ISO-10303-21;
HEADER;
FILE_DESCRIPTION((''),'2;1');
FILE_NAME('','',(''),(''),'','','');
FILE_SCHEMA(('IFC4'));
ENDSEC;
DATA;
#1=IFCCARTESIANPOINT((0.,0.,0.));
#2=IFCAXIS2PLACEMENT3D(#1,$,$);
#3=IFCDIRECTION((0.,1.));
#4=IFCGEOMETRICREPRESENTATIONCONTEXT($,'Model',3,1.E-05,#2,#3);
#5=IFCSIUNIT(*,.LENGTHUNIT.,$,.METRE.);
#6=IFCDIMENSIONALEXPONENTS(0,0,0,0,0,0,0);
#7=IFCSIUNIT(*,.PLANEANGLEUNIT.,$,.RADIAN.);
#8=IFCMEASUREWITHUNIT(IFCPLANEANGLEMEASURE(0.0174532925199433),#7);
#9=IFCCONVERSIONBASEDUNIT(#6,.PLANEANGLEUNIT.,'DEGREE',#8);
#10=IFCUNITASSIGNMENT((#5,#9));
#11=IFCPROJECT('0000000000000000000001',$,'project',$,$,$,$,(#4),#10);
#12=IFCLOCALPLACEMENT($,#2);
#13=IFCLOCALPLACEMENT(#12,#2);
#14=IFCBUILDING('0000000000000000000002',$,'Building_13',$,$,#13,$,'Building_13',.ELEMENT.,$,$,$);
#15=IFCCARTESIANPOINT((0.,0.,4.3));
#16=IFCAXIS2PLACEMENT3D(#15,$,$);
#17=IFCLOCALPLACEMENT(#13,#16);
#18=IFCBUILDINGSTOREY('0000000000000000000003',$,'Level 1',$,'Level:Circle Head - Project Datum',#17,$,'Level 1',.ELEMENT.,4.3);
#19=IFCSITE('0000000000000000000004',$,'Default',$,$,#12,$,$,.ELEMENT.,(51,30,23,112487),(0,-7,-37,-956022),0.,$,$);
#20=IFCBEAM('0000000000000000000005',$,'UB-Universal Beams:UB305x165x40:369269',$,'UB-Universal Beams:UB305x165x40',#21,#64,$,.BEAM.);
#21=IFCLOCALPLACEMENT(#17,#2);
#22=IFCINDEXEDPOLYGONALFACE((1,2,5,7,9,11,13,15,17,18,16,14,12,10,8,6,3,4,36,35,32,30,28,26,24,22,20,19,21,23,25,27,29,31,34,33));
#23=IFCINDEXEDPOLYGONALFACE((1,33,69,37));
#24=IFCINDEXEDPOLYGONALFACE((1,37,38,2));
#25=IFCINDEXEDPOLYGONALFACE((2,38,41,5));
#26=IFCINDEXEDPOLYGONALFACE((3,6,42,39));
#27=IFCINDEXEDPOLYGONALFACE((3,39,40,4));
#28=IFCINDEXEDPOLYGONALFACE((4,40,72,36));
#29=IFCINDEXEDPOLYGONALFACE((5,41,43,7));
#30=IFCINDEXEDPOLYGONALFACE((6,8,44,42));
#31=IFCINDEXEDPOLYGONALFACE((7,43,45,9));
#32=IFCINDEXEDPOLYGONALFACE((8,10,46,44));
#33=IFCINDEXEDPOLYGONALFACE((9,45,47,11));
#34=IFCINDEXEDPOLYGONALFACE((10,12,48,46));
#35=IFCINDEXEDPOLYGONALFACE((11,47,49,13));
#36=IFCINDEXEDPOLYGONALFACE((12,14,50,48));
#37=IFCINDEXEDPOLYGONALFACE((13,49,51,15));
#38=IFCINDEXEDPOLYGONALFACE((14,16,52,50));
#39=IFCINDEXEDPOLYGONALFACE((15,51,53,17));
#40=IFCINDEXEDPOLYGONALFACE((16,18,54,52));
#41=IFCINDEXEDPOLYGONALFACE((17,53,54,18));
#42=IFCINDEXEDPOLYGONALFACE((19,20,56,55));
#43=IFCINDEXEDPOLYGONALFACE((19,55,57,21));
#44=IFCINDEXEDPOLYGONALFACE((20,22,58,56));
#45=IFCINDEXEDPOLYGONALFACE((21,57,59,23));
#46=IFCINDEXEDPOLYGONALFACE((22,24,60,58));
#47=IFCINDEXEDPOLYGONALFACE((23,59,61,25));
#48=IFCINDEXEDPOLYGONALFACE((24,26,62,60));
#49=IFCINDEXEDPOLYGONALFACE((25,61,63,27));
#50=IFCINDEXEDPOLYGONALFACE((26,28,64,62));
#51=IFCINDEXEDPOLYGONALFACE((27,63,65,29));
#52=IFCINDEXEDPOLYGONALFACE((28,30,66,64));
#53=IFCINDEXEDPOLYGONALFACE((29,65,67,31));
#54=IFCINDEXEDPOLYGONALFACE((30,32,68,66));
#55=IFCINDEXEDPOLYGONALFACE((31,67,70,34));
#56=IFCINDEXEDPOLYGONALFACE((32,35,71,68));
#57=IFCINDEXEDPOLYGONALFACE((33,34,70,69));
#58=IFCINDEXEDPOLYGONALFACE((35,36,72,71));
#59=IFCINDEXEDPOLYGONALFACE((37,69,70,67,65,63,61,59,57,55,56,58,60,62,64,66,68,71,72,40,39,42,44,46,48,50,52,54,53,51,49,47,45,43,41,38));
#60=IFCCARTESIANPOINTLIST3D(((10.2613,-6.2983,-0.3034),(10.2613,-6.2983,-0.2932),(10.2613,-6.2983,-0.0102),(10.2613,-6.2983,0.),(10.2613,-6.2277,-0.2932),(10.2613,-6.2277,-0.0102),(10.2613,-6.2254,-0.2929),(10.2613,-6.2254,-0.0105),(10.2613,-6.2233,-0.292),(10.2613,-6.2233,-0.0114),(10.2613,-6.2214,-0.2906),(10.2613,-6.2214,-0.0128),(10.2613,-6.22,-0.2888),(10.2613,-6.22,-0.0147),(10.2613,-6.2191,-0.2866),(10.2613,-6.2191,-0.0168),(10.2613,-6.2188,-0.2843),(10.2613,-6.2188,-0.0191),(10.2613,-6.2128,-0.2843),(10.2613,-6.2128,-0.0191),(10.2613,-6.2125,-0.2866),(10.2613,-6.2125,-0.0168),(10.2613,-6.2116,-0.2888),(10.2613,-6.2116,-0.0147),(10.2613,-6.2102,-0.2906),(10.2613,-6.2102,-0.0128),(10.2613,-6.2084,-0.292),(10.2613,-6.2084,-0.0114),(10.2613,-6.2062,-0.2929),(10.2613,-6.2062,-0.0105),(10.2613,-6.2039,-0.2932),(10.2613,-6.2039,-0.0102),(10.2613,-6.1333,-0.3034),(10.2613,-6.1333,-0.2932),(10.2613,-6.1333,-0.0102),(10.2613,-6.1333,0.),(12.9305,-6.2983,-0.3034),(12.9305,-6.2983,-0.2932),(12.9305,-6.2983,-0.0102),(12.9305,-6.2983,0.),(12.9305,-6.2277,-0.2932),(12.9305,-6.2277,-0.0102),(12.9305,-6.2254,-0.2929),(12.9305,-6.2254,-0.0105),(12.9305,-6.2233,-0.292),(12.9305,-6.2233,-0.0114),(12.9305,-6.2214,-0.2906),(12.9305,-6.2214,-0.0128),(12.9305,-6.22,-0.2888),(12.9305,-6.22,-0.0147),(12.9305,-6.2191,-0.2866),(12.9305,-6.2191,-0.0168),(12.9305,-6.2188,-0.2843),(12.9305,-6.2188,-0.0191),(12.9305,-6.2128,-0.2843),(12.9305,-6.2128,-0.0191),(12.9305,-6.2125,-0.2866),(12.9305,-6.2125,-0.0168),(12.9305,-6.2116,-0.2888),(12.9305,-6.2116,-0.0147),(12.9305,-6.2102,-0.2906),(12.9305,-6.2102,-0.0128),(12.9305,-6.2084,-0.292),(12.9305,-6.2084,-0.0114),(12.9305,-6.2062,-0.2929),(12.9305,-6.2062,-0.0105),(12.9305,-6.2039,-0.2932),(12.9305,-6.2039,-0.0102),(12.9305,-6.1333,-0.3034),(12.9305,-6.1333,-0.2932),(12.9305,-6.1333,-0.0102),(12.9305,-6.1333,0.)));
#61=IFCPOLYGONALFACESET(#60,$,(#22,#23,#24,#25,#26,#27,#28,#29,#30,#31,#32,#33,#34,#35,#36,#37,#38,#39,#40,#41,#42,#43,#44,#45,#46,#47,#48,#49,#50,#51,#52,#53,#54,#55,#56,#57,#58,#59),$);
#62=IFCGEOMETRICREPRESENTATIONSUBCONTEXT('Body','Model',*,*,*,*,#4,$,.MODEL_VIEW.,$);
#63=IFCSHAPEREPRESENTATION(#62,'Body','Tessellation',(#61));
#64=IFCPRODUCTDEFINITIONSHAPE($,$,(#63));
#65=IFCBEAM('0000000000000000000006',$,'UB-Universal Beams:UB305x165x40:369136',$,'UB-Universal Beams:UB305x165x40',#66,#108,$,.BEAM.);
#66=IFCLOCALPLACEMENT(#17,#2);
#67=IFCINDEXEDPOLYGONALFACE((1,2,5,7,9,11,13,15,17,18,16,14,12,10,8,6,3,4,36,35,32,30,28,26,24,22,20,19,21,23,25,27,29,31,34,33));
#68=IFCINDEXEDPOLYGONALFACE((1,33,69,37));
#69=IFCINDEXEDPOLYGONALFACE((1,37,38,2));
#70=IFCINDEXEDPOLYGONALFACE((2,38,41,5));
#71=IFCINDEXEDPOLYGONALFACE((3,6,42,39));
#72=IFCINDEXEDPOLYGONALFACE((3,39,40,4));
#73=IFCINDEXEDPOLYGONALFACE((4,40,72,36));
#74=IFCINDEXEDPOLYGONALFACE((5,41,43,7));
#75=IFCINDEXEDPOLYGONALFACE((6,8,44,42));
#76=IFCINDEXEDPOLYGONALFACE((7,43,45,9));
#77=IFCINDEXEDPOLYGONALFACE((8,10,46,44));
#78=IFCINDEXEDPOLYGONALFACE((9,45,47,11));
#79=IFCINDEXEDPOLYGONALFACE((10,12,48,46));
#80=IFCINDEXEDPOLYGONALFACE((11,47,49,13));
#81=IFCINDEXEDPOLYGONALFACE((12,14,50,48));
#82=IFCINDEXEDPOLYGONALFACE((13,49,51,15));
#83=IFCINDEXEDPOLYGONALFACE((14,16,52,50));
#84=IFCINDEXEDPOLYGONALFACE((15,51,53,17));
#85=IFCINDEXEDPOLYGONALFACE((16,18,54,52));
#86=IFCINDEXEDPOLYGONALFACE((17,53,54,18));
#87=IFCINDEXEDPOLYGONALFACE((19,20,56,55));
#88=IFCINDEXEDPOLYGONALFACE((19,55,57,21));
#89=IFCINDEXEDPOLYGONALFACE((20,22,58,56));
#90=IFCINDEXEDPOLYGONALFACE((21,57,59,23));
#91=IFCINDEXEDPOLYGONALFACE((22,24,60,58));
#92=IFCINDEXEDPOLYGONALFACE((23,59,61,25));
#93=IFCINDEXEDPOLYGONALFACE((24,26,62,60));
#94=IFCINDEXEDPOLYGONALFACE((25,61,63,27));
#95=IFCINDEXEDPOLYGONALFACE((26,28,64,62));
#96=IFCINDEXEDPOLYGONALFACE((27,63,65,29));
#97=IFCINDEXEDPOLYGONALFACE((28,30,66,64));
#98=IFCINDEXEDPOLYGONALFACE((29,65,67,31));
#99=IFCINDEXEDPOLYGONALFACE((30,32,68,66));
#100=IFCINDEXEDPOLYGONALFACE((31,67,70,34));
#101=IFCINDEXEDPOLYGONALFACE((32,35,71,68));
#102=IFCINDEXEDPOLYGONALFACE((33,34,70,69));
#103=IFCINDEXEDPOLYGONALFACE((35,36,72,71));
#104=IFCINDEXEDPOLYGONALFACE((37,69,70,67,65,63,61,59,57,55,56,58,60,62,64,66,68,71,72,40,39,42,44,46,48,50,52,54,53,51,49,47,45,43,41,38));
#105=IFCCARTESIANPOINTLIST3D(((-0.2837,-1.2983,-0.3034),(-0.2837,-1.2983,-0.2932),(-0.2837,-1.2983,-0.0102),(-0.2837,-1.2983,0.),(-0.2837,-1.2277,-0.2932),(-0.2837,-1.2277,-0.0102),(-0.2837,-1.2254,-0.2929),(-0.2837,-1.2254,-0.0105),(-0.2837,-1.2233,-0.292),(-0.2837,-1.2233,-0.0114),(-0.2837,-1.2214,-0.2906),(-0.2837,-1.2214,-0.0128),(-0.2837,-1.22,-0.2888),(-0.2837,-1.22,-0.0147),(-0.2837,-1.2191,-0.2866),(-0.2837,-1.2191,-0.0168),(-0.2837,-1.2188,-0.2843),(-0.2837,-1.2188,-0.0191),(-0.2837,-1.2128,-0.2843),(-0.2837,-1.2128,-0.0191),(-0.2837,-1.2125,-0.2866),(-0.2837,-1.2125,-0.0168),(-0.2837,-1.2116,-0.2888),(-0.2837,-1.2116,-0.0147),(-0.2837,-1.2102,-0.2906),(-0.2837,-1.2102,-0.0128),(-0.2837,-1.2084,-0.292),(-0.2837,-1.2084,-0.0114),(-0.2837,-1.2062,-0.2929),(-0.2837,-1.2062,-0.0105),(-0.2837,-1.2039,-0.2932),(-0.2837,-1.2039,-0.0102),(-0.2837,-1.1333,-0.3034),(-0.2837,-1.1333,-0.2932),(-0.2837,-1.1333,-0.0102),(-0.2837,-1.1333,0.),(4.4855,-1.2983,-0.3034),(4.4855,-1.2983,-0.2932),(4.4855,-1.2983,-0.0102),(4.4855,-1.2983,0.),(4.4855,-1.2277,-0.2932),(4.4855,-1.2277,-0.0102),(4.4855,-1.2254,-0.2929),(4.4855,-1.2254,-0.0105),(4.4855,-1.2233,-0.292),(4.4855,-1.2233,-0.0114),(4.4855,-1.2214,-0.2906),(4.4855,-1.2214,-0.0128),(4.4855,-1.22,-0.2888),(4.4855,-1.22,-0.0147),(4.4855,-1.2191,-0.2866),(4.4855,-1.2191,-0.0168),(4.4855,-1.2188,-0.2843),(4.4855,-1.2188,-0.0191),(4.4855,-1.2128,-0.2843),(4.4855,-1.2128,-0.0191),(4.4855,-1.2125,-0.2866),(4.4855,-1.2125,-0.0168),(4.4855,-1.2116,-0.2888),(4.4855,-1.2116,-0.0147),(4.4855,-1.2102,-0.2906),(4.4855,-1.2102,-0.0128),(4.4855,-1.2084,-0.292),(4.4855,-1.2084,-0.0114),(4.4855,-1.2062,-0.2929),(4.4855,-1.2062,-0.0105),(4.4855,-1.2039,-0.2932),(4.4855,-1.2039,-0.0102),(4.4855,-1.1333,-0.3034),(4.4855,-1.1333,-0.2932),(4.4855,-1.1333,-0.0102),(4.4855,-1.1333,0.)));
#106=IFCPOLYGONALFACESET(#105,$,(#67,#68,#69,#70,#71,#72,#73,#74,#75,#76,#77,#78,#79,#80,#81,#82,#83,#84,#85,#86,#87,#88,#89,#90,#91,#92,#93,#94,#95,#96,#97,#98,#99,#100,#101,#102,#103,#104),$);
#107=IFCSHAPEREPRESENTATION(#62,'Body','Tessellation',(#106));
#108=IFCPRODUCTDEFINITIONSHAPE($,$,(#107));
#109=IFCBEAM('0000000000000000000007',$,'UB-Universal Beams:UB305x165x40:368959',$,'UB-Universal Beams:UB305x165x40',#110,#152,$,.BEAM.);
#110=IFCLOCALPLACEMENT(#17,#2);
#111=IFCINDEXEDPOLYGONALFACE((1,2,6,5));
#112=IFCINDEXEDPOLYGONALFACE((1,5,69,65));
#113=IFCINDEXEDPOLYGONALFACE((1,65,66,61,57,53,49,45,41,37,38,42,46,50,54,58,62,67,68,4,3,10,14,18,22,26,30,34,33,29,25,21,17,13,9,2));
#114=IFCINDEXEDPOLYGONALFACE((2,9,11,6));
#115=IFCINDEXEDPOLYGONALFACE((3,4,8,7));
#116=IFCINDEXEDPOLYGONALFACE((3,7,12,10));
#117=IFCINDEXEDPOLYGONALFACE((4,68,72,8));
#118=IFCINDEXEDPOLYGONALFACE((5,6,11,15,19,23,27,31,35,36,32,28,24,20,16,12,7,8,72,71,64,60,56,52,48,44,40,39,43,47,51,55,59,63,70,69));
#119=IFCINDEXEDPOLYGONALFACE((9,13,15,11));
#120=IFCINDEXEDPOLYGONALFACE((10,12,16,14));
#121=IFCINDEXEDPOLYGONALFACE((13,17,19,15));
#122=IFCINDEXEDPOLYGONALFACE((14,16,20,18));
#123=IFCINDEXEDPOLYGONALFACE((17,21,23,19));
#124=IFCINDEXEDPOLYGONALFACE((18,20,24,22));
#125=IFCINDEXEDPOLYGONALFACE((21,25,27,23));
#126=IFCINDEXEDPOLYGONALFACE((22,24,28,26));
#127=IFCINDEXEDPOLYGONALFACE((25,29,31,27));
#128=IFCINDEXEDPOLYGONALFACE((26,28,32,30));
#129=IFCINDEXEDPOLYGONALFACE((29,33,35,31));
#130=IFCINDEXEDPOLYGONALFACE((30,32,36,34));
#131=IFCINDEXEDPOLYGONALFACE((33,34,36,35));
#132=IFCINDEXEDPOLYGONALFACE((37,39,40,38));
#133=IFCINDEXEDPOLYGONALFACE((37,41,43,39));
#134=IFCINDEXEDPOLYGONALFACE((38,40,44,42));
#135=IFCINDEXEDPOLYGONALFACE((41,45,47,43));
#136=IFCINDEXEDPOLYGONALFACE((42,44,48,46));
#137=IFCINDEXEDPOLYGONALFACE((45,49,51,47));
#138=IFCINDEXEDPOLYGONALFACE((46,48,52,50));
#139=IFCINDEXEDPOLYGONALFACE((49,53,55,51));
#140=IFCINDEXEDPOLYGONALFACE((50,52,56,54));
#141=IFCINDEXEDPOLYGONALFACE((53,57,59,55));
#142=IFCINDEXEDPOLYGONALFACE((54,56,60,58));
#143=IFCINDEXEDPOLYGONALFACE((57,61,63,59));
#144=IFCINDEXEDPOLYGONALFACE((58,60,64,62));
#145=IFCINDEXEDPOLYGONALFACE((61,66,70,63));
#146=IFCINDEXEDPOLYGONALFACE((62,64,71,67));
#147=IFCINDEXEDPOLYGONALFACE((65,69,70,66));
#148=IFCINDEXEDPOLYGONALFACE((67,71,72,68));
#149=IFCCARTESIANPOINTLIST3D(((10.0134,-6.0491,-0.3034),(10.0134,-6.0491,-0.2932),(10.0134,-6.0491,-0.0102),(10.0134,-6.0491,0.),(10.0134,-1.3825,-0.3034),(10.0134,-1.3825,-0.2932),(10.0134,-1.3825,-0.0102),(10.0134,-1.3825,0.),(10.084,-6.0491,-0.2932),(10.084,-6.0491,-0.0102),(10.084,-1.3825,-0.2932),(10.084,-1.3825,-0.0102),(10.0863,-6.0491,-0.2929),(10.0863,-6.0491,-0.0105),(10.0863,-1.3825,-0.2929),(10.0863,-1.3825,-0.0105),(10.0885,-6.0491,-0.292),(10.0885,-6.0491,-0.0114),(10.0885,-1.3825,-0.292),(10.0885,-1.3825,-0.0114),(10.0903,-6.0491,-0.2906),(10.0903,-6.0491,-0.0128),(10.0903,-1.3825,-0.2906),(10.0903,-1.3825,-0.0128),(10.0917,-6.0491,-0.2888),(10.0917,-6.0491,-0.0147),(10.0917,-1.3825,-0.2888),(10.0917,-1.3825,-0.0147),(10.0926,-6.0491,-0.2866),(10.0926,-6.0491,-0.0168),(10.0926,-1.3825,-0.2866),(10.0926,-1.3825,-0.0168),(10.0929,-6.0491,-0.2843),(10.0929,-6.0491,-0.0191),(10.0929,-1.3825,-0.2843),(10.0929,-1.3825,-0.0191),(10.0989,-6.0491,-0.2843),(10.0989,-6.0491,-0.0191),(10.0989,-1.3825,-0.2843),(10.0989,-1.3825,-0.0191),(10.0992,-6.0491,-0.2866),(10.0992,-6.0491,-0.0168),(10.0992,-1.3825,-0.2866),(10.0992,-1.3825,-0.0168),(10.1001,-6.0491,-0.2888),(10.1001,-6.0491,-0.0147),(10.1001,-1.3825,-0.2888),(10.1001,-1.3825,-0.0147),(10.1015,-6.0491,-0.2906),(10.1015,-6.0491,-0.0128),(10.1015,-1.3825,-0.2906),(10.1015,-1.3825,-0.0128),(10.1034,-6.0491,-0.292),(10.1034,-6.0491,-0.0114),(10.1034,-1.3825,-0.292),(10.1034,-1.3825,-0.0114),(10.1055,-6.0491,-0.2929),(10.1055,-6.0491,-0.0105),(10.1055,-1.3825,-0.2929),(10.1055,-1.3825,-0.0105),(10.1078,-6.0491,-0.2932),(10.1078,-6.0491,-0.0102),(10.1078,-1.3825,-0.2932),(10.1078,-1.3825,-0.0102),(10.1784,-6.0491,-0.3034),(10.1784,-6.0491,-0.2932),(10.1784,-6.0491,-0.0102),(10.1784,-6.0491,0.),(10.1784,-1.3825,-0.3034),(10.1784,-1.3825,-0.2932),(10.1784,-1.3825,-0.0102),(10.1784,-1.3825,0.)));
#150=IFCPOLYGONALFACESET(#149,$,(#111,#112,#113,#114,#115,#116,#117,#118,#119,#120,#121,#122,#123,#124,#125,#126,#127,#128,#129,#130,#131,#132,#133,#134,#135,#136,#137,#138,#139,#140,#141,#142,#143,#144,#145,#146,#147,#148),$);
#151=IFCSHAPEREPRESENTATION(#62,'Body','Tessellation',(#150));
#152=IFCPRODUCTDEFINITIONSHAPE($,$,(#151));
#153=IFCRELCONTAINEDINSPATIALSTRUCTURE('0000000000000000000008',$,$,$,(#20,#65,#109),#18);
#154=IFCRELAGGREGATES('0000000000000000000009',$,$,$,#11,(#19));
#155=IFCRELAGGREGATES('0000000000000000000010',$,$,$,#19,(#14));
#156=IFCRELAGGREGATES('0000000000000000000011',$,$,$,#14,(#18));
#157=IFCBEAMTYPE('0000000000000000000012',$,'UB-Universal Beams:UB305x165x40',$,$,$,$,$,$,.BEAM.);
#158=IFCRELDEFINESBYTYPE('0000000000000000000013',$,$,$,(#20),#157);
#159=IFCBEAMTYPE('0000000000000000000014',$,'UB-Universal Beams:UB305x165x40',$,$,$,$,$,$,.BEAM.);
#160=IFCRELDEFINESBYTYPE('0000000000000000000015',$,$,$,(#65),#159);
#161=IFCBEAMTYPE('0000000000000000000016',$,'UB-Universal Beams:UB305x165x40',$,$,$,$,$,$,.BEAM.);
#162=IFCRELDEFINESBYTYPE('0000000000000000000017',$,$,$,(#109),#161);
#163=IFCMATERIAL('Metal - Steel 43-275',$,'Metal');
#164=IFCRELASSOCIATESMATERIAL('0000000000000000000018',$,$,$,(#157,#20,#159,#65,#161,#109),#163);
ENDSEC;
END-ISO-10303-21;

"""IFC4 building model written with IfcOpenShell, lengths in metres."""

from ifc_helpers import new_model, entity, si_unit, converted_unit, direction, frame, origin, place, context, subcontext, project, spatial, line, arc, indexed_curve, outline, extrude, source, transform, mapped, material, type_object, type_shapes, element, save


model = new_model("IFC4")

# Units and contexts
model_context = context("Model", 3, precision=1e-05, world=origin(), true_north=direction((0.0, 1.0)))
body_context = subcontext(model_context, "Body", "Model", "MODEL_VIEW")
ifc_project = project(units=[si_unit("LENGTHUNIT", "METRE"), converted_unit("PLANEANGLEUNIT", "DEGREE", entity("IfcPlaneAngleMeasure", 0.0174532925199433), si_unit("PLANEANGLEUNIT", "RADIAN"), dimensions=[0, 0, 0, 0, 0, 0, 0])], contexts=[model_context])

# Site, building, storey
site_placement = place(None, origin())
site = spatial("IfcSite", under=ifc_project, at=site_placement, Name="Default", CompositionType="ELEMENT", RefLatitude=(51, 30, 23, 112487), RefLongitude=(0, -7, -37, -956022), RefElevation=0.0)
building_placement = place(site_placement, origin())
building = spatial("IfcBuilding", under=site, at=building_placement, Name="Building_13", LongName="Building_13", CompositionType="ELEMENT")
storey_placement = place(building_placement, frame((0.0, 0.0, 4.3)))
storey = spatial("IfcBuildingStorey", under=building, at=storey_placement, Name="Level 1", ObjectType="Level:Circle Head - Project Datum", LongName="Level 1", CompositionType="ELEMENT", Elevation=4.3)

# Beams
ifc_material_1 = material(Name="Metal - Steel 43-275", Category="Metal")
beam_type_1 = type_object("IfcBeamType", Name="UB-Universal Beams:UB305x165x40", PredefinedType="BEAM", material=ifc_material_1)
shared_shape_1 = source(origin(), body_context, "Body", "SweptSolid", [
    extrude(outline(indexed_curve([(-0.0825, -0.1415), (-0.0825, -0.1517), (0.0825, -0.1517), (0.0825, -0.1415), (0.0119, -0.1415), (0.0056, -0.1389), (0.003, -0.1326), (0.003, 0.1326), (0.0056, 0.1389), (0.0119, 0.1415), (0.0825, 0.1415), (0.0825, 0.1517), (-0.0825, 0.1517), (-0.0825, 0.1415), (-0.0119, 0.1415), (-0.0056, 0.1389), (-0.003, 0.1326), (-0.003, -0.1326), (-0.0056, -0.1389), (-0.0119, -0.1415)], segments=[line(1, 2, 3, 4, 5), arc(5, 6, 7), line(7, 8), arc(8, 9, 10), line(10, 11, 12, 13, 14, 15), arc(15, 16, 17), line(17, 18), arc(18, 19, 20), line(20, 1)], self_intersect=False)), frame((-1.3346, 0.0, 0.0), z_axis=(-1.0, 0.0, 0.0), x_axis=(0.0, -1.0, 0.0)), (0.0, 0.0, -1.0), 2.6692),
])
type_shapes(beam_type_1, [shared_shape_1])
beam_1_placement = place(storey_placement, frame((11.5959, -6.2158, -0.1517)))
element("IfcBeam", 1, at=beam_1_placement, inside=storey, type_object=beam_type_1, material=ifc_material_1, Name="UB-Universal Beams:UB305x165x40:369269", ObjectType="UB-Universal Beams:UB305x165x40", PredefinedType="BEAM", context=body_context, shape_type="MappedRepresentation", body=[
    mapped(shared_shape_1, transform((0.0, 0.0, 0.0), scale=1.0)),
])
beam_type_2 = type_object("IfcBeamType", Name="UB-Universal Beams:UB305x165x40", PredefinedType="BEAM", material=ifc_material_1)
shared_shape_2 = source(origin(), body_context, "Body", "SweptSolid", [
    extrude(outline(indexed_curve([(-0.0825, -0.1415), (-0.0825, -0.1517), (0.0825, -0.1517), (0.0825, -0.1415), (0.0119, -0.1415), (0.0056, -0.1389), (0.003, -0.1326), (0.003, 0.1326), (0.0056, 0.1389), (0.0119, 0.1415), (0.0825, 0.1415), (0.0825, 0.1517), (-0.0825, 0.1517), (-0.0825, 0.1415), (-0.0119, 0.1415), (-0.0056, 0.1389), (-0.003, 0.1326), (-0.003, -0.1326), (-0.0056, -0.1389), (-0.0119, -0.1415)], segments=[line(1, 2, 3, 4, 5), arc(5, 6, 7), line(7, 8), arc(8, 9, 10), line(10, 11, 12, 13, 14, 15), arc(15, 16, 17), line(17, 18), arc(18, 19, 20), line(20, 1)], self_intersect=False)), frame((-2.3846, 0.0, 0.0), z_axis=(-1.0, 0.0, 0.0), x_axis=(0.0, -1.0, 0.0)), (0.0, 0.0, -1.0), 4.7692),
])
type_shapes(beam_type_2, [shared_shape_2])
beam_2_placement = place(storey_placement, frame((2.1009, -1.2158, -0.1517), z_axis=(0.0, 0.0, 1.0), x_axis=(-1.0, 0.0, 0.0)))
element("IfcBeam", 2, at=beam_2_placement, inside=storey, type_object=beam_type_2, material=ifc_material_1, Name="UB-Universal Beams:UB305x165x40:369136", ObjectType="UB-Universal Beams:UB305x165x40", PredefinedType="BEAM", context=body_context, shape_type="MappedRepresentation", body=[
    mapped(shared_shape_2, transform((0.0, 0.0, 0.0), scale=1.0)),
])
beam_type_3 = type_object("IfcBeamType", Name="UB-Universal Beams:UB305x165x40", PredefinedType="BEAM", material=ifc_material_1)
shared_shape_3 = source(origin(), body_context, "Body", "SweptSolid", [
    extrude(outline(indexed_curve([(-0.0825, -0.1415), (-0.0825, -0.1517), (0.0825, -0.1517), (0.0825, -0.1415), (0.0119, -0.1415), (0.0056, -0.1389), (0.003, -0.1326), (0.003, 0.1326), (0.0056, 0.1389), (0.0119, 0.1415), (0.0825, 0.1415), (0.0825, 0.1517), (-0.0825, 0.1517), (-0.0825, 0.1415), (-0.0119, 0.1415), (-0.0056, 0.1389), (-0.003, 0.1326), (-0.003, -0.1326), (-0.0056, -0.1389), (-0.0119, -0.1415)], segments=[line(1, 2, 3, 4, 5), arc(5, 6, 7), line(7, 8), arc(8, 9, 10), line(10, 11, 12, 13, 14, 15), arc(15, 16, 17), line(17, 18), arc(18, 19, 20), line(20, 1)], self_intersect=False)), frame((-2.3333, 0.0, 0.0), z_axis=(-1.0, 0.0, 0.0), x_axis=(0.0, -1.0, 0.0)), (0.0, 0.0, -1.0), 4.6666),
])
type_shapes(beam_type_3, [shared_shape_3])
for number, where, z_axis, x_axis, name in (
    (3, (10.0959, -3.7158, -0.1517), (0.0, 0.0, 1.0), (0.0, -1.0, 0.0), "UB-Universal Beams:UB305x165x40:368959"),
):
    element("IfcBeam", number, at=place(storey_placement, frame(where, z_axis=z_axis, x_axis=x_axis)), inside=storey, type_object=beam_type_3, material=ifc_material_1, Name=name, ObjectType="UB-Universal Beams:UB305x165x40", PredefinedType="BEAM", context=body_context, shape_type="MappedRepresentation", body=[
        mapped(shared_shape_3, transform((0.0, 0.0, 0.0), scale=1.0)),
    ])

save(model, "model.ifc")
